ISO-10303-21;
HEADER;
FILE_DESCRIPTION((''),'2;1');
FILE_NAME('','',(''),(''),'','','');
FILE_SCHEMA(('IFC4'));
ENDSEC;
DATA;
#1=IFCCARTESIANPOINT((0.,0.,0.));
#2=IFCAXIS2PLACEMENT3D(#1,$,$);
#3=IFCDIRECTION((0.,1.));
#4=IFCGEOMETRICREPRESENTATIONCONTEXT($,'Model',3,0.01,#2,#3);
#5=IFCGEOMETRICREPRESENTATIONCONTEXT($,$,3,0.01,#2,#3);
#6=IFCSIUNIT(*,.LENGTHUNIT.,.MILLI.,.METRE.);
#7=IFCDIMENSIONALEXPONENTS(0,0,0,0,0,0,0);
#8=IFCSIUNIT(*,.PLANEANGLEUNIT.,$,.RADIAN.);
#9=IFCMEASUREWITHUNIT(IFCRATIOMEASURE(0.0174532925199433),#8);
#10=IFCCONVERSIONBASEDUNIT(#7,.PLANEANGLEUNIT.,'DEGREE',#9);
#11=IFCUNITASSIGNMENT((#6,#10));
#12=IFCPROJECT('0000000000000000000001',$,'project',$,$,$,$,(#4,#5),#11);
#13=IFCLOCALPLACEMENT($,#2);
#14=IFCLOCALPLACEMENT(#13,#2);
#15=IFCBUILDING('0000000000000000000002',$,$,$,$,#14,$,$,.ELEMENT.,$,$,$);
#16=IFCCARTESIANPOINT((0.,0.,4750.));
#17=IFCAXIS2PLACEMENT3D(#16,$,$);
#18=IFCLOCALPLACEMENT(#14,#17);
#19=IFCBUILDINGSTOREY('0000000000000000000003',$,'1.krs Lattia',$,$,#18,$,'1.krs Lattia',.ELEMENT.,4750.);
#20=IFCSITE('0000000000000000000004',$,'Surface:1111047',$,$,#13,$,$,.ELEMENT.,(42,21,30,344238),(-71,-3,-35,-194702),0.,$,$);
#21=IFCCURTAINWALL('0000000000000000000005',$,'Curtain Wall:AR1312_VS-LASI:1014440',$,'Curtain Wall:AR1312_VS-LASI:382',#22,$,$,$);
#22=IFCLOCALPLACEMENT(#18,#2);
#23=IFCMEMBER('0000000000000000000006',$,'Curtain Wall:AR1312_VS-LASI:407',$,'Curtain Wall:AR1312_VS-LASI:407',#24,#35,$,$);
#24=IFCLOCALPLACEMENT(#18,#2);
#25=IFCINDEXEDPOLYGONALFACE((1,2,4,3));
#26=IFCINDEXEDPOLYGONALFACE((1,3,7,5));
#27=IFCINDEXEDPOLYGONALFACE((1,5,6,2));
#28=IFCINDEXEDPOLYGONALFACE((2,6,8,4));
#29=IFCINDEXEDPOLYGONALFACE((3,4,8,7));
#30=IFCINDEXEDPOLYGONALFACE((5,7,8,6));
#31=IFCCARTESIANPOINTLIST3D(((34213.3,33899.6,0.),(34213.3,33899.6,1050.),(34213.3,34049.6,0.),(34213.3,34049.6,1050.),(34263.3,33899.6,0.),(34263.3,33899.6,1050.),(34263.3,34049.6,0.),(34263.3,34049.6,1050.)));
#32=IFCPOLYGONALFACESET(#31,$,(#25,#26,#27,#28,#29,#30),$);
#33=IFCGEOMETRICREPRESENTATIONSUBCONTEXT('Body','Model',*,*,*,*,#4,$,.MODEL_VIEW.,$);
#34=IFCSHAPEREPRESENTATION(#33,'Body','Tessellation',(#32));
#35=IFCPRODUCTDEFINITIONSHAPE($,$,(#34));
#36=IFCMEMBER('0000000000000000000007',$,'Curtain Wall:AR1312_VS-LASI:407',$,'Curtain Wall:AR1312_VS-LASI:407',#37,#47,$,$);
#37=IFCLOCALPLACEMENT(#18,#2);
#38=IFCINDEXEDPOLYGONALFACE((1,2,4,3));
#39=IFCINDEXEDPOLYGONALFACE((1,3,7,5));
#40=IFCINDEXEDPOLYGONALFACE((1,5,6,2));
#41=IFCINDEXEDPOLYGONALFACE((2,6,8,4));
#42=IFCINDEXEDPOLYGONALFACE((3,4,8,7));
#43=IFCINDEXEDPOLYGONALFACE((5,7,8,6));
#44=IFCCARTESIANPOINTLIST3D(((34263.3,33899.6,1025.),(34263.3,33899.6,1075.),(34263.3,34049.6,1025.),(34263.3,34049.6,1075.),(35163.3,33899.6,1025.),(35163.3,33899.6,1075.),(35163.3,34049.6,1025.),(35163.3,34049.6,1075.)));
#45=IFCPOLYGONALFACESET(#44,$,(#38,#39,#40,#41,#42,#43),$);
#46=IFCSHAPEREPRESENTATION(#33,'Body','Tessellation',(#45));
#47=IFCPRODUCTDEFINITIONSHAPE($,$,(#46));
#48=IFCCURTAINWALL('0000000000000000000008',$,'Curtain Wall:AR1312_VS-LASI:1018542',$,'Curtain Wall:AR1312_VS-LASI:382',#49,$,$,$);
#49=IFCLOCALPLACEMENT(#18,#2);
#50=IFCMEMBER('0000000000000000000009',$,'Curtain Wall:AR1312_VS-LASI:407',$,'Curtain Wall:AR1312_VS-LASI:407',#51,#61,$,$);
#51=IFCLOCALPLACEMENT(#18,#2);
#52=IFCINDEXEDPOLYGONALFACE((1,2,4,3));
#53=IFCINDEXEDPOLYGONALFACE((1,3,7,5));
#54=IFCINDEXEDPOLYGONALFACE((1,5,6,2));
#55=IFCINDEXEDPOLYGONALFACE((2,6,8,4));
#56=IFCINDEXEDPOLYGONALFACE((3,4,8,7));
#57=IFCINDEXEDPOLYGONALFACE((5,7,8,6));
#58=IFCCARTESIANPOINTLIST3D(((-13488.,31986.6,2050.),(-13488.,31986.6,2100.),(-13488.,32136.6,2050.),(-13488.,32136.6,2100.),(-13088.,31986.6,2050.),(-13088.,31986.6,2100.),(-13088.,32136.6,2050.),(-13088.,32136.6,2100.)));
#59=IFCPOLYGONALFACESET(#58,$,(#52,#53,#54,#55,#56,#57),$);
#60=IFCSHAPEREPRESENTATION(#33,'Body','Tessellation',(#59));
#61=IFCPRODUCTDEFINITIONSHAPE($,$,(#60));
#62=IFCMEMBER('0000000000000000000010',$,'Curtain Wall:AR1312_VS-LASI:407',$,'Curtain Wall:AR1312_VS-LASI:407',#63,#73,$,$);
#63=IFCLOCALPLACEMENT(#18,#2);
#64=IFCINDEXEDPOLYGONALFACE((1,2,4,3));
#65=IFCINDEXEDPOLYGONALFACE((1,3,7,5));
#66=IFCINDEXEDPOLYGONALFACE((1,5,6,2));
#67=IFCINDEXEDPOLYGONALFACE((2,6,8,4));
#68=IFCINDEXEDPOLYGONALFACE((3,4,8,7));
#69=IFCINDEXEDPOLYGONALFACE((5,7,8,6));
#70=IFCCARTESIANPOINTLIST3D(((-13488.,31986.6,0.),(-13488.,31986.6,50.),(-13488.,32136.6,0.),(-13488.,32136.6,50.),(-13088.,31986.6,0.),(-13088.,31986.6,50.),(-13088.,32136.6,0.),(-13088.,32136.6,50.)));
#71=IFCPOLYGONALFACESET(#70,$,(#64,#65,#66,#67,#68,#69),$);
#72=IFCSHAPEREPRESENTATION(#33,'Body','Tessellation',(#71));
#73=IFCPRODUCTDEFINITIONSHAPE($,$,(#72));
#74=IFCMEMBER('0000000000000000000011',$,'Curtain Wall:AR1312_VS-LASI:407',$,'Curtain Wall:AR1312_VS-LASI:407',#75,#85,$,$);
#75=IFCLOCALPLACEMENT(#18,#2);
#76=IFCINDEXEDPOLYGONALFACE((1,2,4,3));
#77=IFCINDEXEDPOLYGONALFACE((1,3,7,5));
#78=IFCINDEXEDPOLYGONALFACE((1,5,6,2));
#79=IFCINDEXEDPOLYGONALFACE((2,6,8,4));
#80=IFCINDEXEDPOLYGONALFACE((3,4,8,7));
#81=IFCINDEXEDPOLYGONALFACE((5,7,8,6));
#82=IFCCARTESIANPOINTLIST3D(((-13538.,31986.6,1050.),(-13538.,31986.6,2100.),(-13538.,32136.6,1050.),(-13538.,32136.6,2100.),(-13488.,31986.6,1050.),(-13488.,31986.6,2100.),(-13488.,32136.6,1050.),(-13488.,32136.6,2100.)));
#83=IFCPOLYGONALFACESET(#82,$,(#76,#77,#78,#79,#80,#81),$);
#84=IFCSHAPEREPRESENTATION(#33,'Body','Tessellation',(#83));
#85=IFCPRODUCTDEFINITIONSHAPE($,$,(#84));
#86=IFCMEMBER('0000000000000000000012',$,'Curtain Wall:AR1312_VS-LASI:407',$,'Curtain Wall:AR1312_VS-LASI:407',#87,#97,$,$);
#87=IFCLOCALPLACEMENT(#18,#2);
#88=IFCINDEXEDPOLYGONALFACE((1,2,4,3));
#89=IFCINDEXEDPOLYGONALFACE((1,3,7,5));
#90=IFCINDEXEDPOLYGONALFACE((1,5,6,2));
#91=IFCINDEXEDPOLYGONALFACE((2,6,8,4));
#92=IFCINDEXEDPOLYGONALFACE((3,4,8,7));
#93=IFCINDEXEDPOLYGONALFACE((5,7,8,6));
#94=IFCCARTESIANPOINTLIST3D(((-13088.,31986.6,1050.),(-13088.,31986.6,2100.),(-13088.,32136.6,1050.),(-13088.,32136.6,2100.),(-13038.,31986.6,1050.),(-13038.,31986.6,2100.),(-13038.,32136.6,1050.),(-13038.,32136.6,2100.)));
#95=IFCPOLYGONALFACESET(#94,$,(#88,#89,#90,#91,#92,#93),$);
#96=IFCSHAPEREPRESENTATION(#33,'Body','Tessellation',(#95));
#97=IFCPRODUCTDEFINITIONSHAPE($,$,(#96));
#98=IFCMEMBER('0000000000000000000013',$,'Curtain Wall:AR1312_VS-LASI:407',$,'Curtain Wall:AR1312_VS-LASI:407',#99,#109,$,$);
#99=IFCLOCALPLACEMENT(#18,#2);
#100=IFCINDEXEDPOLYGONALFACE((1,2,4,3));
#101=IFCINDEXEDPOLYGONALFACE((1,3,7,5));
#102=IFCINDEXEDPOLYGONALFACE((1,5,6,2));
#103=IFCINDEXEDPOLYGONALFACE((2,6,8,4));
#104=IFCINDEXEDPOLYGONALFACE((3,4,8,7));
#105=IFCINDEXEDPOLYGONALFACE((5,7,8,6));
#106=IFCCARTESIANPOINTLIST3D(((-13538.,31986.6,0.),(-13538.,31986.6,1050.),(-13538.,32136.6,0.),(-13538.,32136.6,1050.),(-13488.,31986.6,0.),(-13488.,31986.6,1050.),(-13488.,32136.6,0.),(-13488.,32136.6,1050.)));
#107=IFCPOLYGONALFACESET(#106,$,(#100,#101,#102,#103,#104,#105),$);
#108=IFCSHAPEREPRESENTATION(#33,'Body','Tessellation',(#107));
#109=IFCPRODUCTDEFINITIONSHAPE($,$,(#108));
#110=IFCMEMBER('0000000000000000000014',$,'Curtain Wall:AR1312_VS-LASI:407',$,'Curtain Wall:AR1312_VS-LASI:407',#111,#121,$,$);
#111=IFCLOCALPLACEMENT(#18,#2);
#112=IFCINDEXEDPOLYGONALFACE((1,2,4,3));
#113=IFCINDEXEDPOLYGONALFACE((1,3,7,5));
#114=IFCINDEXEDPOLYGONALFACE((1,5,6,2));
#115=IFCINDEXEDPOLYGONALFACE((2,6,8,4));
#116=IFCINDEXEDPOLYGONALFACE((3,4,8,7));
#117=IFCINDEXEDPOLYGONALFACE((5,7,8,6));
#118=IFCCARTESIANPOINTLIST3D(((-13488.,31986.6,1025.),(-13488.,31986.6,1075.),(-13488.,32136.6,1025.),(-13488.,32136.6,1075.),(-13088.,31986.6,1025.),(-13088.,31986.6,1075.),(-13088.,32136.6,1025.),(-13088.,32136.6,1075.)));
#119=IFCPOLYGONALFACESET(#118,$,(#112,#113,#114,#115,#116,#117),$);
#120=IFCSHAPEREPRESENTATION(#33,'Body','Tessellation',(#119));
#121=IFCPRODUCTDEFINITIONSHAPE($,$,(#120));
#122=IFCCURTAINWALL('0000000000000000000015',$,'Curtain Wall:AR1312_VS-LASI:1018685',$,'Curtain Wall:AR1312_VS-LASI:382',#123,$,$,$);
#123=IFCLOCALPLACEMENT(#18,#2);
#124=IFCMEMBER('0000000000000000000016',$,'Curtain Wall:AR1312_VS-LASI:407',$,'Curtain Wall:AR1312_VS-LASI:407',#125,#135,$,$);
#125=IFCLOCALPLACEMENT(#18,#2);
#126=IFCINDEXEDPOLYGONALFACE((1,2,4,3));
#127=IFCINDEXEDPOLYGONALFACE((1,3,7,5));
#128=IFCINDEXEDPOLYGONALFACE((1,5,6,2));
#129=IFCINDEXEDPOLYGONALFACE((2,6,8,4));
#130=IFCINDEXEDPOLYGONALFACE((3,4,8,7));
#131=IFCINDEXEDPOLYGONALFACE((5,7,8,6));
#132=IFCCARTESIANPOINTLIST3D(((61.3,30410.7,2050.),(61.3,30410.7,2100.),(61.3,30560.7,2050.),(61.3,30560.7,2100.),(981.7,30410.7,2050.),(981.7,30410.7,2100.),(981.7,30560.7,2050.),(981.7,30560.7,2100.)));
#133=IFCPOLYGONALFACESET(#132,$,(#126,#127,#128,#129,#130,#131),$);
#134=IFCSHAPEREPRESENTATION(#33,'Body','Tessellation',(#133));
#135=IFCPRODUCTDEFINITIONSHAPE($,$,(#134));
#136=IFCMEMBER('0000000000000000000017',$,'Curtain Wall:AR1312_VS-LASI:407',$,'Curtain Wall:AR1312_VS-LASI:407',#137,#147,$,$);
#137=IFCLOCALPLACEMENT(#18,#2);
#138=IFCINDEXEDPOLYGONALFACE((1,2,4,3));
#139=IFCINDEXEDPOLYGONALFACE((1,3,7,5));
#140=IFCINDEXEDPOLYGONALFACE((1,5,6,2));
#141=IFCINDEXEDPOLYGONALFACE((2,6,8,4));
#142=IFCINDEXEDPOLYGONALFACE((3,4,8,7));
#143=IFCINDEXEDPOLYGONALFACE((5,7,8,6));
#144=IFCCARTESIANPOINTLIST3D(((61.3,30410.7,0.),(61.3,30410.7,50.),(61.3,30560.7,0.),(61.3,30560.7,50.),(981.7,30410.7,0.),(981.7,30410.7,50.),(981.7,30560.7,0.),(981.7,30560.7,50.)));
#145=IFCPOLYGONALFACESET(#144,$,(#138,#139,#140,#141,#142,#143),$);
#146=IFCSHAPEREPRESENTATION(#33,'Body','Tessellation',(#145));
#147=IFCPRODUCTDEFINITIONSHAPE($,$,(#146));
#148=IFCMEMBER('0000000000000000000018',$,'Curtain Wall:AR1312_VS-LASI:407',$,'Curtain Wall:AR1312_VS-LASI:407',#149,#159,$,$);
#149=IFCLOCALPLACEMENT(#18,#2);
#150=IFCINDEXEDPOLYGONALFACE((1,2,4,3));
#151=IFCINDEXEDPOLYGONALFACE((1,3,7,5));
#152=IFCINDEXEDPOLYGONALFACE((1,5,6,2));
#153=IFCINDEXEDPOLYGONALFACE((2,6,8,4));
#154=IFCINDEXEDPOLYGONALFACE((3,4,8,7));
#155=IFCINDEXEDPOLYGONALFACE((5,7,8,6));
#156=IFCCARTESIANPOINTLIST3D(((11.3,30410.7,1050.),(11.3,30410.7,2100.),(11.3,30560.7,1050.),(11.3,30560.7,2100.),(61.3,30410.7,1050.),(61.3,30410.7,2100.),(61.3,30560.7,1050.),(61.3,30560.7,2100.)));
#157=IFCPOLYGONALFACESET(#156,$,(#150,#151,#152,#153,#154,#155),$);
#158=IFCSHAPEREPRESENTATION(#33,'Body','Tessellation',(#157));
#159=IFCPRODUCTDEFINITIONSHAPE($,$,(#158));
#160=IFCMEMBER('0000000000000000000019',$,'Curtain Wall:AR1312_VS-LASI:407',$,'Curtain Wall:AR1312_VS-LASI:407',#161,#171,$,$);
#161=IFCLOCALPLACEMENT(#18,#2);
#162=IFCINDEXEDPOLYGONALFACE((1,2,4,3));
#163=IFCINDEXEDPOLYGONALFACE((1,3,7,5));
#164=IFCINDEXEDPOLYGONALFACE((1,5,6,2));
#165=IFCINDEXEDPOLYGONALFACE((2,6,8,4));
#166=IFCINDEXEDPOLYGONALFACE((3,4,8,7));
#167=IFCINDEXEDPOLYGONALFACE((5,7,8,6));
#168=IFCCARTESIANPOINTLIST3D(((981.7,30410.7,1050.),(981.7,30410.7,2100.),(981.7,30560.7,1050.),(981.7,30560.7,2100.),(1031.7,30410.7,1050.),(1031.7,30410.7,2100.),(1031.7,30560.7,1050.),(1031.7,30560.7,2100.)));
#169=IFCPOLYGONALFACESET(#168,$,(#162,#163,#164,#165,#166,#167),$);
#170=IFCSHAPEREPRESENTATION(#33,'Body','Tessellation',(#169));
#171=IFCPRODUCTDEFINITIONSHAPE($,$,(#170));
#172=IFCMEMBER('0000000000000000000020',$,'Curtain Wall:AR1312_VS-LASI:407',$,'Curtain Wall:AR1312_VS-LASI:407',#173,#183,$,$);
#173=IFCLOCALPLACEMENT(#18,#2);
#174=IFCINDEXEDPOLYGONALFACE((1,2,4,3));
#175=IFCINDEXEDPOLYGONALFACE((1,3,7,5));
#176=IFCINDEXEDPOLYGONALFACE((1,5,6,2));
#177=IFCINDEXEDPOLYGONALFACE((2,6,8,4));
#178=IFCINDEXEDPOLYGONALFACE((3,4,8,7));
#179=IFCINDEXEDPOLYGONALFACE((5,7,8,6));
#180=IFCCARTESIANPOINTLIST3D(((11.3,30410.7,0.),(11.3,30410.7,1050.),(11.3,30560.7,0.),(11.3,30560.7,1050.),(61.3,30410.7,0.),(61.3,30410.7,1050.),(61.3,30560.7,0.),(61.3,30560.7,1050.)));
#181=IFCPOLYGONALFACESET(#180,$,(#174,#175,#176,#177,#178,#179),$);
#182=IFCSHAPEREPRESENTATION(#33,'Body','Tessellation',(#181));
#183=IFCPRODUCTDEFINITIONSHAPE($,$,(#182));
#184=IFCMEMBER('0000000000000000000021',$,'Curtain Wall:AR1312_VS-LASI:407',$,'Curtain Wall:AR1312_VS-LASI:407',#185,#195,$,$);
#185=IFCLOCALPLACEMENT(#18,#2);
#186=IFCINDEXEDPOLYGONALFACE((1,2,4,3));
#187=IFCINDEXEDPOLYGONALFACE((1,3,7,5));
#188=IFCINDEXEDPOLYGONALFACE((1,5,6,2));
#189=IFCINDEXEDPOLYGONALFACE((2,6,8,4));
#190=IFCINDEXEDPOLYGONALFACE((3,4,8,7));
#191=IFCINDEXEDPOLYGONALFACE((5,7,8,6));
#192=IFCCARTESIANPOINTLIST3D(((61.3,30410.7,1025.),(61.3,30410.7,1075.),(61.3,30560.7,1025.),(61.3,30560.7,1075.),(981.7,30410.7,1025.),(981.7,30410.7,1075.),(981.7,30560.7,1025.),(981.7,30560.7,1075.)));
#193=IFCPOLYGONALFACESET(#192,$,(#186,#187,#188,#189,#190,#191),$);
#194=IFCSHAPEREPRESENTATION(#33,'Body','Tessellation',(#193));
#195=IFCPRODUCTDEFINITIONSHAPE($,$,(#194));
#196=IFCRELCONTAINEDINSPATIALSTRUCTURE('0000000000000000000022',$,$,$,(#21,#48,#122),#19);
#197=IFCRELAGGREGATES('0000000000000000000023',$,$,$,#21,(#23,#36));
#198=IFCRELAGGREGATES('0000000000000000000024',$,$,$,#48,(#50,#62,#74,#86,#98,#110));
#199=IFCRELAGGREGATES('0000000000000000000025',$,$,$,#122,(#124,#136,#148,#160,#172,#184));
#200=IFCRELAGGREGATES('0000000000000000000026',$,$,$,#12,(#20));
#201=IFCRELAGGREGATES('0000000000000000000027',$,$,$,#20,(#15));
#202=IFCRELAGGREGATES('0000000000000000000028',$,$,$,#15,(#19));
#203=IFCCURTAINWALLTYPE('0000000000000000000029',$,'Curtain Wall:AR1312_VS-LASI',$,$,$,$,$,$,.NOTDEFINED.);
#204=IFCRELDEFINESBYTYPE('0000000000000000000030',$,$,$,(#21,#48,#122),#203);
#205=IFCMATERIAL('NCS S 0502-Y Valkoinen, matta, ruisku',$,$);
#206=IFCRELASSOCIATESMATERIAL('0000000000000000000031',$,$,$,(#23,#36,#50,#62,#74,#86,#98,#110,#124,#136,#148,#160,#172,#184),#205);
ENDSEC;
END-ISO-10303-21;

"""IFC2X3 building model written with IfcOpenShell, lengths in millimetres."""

from ifc_helpers import new_model, entity, si_unit, converted_unit, direction, frame, frame_2d, origin, origin_2d_with_axis, place, context, subcontext, project, spatial, rectangle, extrude, material, type_object, element, aggregate, save


model = new_model("IFC2X3")

# Units and contexts
model_context = context("Model", 3, precision=0.01, world=origin(), true_north=direction((0.0, 1.0)))
context_of_model = context(None, 3, precision=0.01, world=origin(), true_north=direction((0.0, 1.0)))
body_context = subcontext(model_context, "Body", "Model", "MODEL_VIEW")
ifc_project = project(units=[si_unit("LENGTHUNIT", "METRE", prefix="MILLI"), converted_unit("PLANEANGLEUNIT", "DEGREE", entity("IfcRatioMeasure", 0.0174532925199433), si_unit("PLANEANGLEUNIT", "RADIAN"), dimensions=[0, 0, 0, 0, 0, 0, 0])], contexts=[model_context, context_of_model])

# Site, building, storey
site_placement = place(None, origin())
site = spatial("IfcSite", under=ifc_project, at=site_placement, Name="Surface:1111047", CompositionType="ELEMENT", RefLatitude=(42, 21, 30, 344238), RefLongitude=(-71, -3, -35, -194702), RefElevation=0.0)
building_placement = place(site_placement, origin())
building = spatial("IfcBuilding", under=site, at=building_placement, CompositionType="ELEMENT")
storey_placement = place(building_placement, frame((0.0, 0.0, 4750.0)))
storey = spatial("IfcBuildingStorey", under=building, at=storey_placement, Name="1.krs Lattia", LongName="1.krs Lattia", CompositionType="ELEMENT", Elevation=4750.0)

# Curtain walls, members
curtain_wall_type = type_object("IfcCurtainWallType", Name="Curtain Wall:AR1312_VS-LASI", PredefinedType="NOTDEFINED")
ifc_material = material(Name="NCS S 0502-Y Valkoinen, matta, ruisku")
curtain_wall_1_placement = place(storey_placement, frame((0.0, 0.0, -4750.0)))
curtain_wall_1 = element("IfcCurtainWall", 1, at=curtain_wall_1_placement, inside=storey, type_object=curtain_wall_type, Name="Curtain Wall:AR1312_VS-LASI:1014440", ObjectType="Curtain Wall:AR1312_VS-LASI:382")
member_1_placement = place(curtain_wall_1_placement, frame((0.0, 0.0, 4750.0)))
member_1 = element("IfcMember", 2, at=member_1_placement, material=ifc_material, Name="Curtain Wall:AR1312_VS-LASI:407", ObjectType="Curtain Wall:AR1312_VS-LASI:407", context=body_context, shape_type="SweptSolid", body=[
    extrude(rectangle(XDim=50.0, YDim=150.0, at=frame_2d((0.0, 0.0), x_axis=(1.0, 0.0))), frame((34238.3, 33974.6, 1050.0), z_axis=(0.0, 0.0, -1.0), x_axis=(-1.0, 0.0, 0.0)), (0.0, 0.0, 1.0), 1050.0),
])
member_2_placement = place(curtain_wall_1_placement, frame((0.0, 0.0, 4750.0)))
member_2 = element("IfcMember", 3, at=member_2_placement, material=ifc_material, Name="Curtain Wall:AR1312_VS-LASI:407", ObjectType="Curtain Wall:AR1312_VS-LASI:407", context=body_context, shape_type="SweptSolid", body=[
    extrude(rectangle(XDim=50.0, YDim=150.0, at=frame_2d((0.0, 0.0), x_axis=(1.0, 0.0))), frame((35163.3, 33974.6, 1050.0), z_axis=(-1.0, 0.0, 0.0), x_axis=(0.0, 0.0, -1.0)), (0.0, 0.0, 1.0), 900.0),
])
aggregate(curtain_wall_1, [member_1, member_2])
curtain_wall_2_placement = place(storey_placement, frame((0.0, 0.0, -4750.0)))
curtain_wall_2 = element("IfcCurtainWall", 4, at=curtain_wall_2_placement, inside=storey, type_object=curtain_wall_type, Name="Curtain Wall:AR1312_VS-LASI:1018542", ObjectType="Curtain Wall:AR1312_VS-LASI:382")
member_3_placement = place(curtain_wall_2_placement, frame((0.0, 0.0, 4750.0)))
member_3 = element("IfcMember", 5, at=member_3_placement, material=ifc_material, Name="Curtain Wall:AR1312_VS-LASI:407", ObjectType="Curtain Wall:AR1312_VS-LASI:407", context=body_context, shape_type="SweptSolid", body=[
    extrude(rectangle(XDim=50.0, YDim=150.0, at=frame_2d((0.0, 0.0), x_axis=(1.0, 0.0))), frame((-13088.0, 32061.6, 2075.0), z_axis=(-1.0, 0.0, 0.0), x_axis=(0.0, 0.0, -1.0)), (0.0, 0.0, 1.0), 400.0),
])
member_4_placement = place(curtain_wall_2_placement, frame((0.0, 0.0, 4750.0)))
member_4 = element("IfcMember", 6, at=member_4_placement, material=ifc_material, Name="Curtain Wall:AR1312_VS-LASI:407", ObjectType="Curtain Wall:AR1312_VS-LASI:407", context=body_context, shape_type="SweptSolid", body=[
    extrude(rectangle(XDim=50.0, YDim=150.0, at=frame_2d((0.0, 0.0), x_axis=(1.0, 0.0))), frame((-13488.0, 32061.6, 25.0), z_axis=(1.0, 0.0, 0.0), x_axis=(0.0, 0.0, -1.0)), (0.0, 0.0, 1.0), 400.0),
])
member_5_placement = place(curtain_wall_2_placement, frame((0.0, 0.0, 4750.0)))
member_5 = element("IfcMember", 7, at=member_5_placement, material=ifc_material, Name="Curtain Wall:AR1312_VS-LASI:407", ObjectType="Curtain Wall:AR1312_VS-LASI:407", context=body_context, shape_type="SweptSolid", body=[
    extrude(rectangle(XDim=50.0, YDim=150.0, at=frame_2d((0.0, 0.0), x_axis=(1.0, 0.0))), frame((-13513.0, 32061.6, 2100.0), z_axis=(0.0, 0.0, -1.0), x_axis=(-1.0, 0.0, 0.0)), (0.0, 0.0, 1.0), 1050.0),
])
member_6_placement = place(curtain_wall_2_placement, frame((0.0, 0.0, 4750.0)))
member_6 = element("IfcMember", 8, at=member_6_placement, material=ifc_material, Name="Curtain Wall:AR1312_VS-LASI:407", ObjectType="Curtain Wall:AR1312_VS-LASI:407", context=body_context, shape_type="SweptSolid", body=[
    extrude(rectangle(XDim=50.0, YDim=150.0, at=frame_2d((0.0, 0.0), x_axis=(1.0, 0.0))), frame((-13063.0, 32061.6, 1050.0), z_axis=(0.0, 0.0, 1.0), x_axis=(-1.0, 0.0, 0.0)), (0.0, 0.0, 1.0), 1050.0),
])
member_7_placement = place(curtain_wall_2_placement, frame((0.0, 0.0, 4750.0)))
member_7 = element("IfcMember", 9, at=member_7_placement, material=ifc_material, Name="Curtain Wall:AR1312_VS-LASI:407", ObjectType="Curtain Wall:AR1312_VS-LASI:407", context=body_context, shape_type="SweptSolid", body=[
    extrude(rectangle(XDim=50.0, YDim=150.0, at=frame_2d((0.0, 0.0), x_axis=(1.0, 0.0))), frame((-13513.0, 32061.6, 1050.0), z_axis=(0.0, 0.0, -1.0), x_axis=(-1.0, 0.0, 0.0)), (0.0, 0.0, 1.0), 1050.0),
])
member_8_placement = place(curtain_wall_2_placement, frame((0.0, 0.0, 4750.0)))
member_8 = element("IfcMember", 10, at=member_8_placement, material=ifc_material, Name="Curtain Wall:AR1312_VS-LASI:407", ObjectType="Curtain Wall:AR1312_VS-LASI:407", context=body_context, shape_type="SweptSolid", body=[
    extrude(rectangle(XDim=50.0, YDim=150.0, at=origin_2d_with_axis()), frame((-13088.0, 32061.6, 1050.0), z_axis=(-1.0, 0.0, 0.0), x_axis=(0.0, 0.0, -1.0)), (0.0, 0.0, 1.0), 400.0),
])
aggregate(curtain_wall_2, [member_3, member_4, member_5, member_6, member_7, member_8])
curtain_wall_3_placement = place(storey_placement, frame((0.0, 0.0, -4750.0)))
curtain_wall_3 = element("IfcCurtainWall", 11, at=curtain_wall_3_placement, inside=storey, type_object=curtain_wall_type, Name="Curtain Wall:AR1312_VS-LASI:1018685", ObjectType="Curtain Wall:AR1312_VS-LASI:382")
member_9_placement = place(curtain_wall_3_placement, frame((0.0, 0.0, 4750.0)))
member_9 = element("IfcMember", 12, at=member_9_placement, material=ifc_material, Name="Curtain Wall:AR1312_VS-LASI:407", ObjectType="Curtain Wall:AR1312_VS-LASI:407", context=body_context, shape_type="SweptSolid", body=[
    extrude(rectangle(XDim=50.0, YDim=150.0, at=frame_2d((0.0, 0.0), x_axis=(1.0, 0.0))), frame((981.7, 30485.7, 2075.0), z_axis=(-1.0, 0.0, 0.0), x_axis=(0.0, 0.0, -1.0)), (0.0, 0.0, 1.0), 920.4),
])
member_10_placement = place(curtain_wall_3_placement, frame((0.0, 0.0, 4750.0)))
member_10 = element("IfcMember", 13, at=member_10_placement, material=ifc_material, Name="Curtain Wall:AR1312_VS-LASI:407", ObjectType="Curtain Wall:AR1312_VS-LASI:407", context=body_context, shape_type="SweptSolid", body=[
    extrude(rectangle(XDim=50.0, YDim=150.0, at=frame_2d((0.0, 0.0), x_axis=(1.0, 0.0))), frame((61.3, 30485.7, 25.0), z_axis=(1.0, 0.0, 0.0), x_axis=(0.0, 0.0, -1.0)), (0.0, 0.0, 1.0), 920.4),
])
member_11_placement = place(curtain_wall_3_placement, frame((0.0, 0.0, 4750.0)))
member_11 = element("IfcMember", 14, at=member_11_placement, material=ifc_material, Name="Curtain Wall:AR1312_VS-LASI:407", ObjectType="Curtain Wall:AR1312_VS-LASI:407", context=body_context, shape_type="SweptSolid", body=[
    extrude(rectangle(XDim=50.0, YDim=150.0, at=frame_2d((0.0, 0.0), x_axis=(1.0, 0.0))), frame((36.3, 30485.7, 2100.0), z_axis=(0.0, 0.0, -1.0), x_axis=(-1.0, 0.0, 0.0)), (0.0, 0.0, 1.0), 1050.0),
])
member_12_placement = place(curtain_wall_3_placement, frame((0.0, 0.0, 4750.0)))
member_12 = element("IfcMember", 15, at=member_12_placement, material=ifc_material, Name="Curtain Wall:AR1312_VS-LASI:407", ObjectType="Curtain Wall:AR1312_VS-LASI:407", context=body_context, shape_type="SweptSolid", body=[
    extrude(rectangle(XDim=50.0, YDim=150.0, at=origin_2d_with_axis()), frame((1006.7, 30485.7, 1050.0), z_axis=(0.0, 0.0, 1.0), x_axis=(-1.0, 0.0, 0.0)), (0.0, 0.0, 1.0), 1050.0),
])
member_13_placement = place(curtain_wall_3_placement, frame((0.0, 0.0, 4750.0)))
member_13 = element("IfcMember", 16, at=member_13_placement, material=ifc_material, Name="Curtain Wall:AR1312_VS-LASI:407", ObjectType="Curtain Wall:AR1312_VS-LASI:407", context=body_context, shape_type="SweptSolid", body=[
    extrude(rectangle(XDim=50.0, YDim=150.0, at=frame_2d((0.0, 0.0), x_axis=(1.0, 0.0))), frame((36.3, 30485.7, 1050.0), z_axis=(0.0, 0.0, -1.0), x_axis=(-1.0, 0.0, 0.0)), (0.0, 0.0, 1.0), 1050.0),
])
member_14_placement = place(curtain_wall_3_placement, frame((0.0, 0.0, 4750.0)))
member_14 = element("IfcMember", 17, at=member_14_placement, material=ifc_material, Name="Curtain Wall:AR1312_VS-LASI:407", ObjectType="Curtain Wall:AR1312_VS-LASI:407", context=body_context, shape_type="SweptSolid", body=[
    extrude(rectangle(XDim=50.0, YDim=150.0, at=frame_2d((0.0, 0.0), x_axis=(1.0, 0.0))), frame((981.7, 30485.7, 1050.0), z_axis=(-1.0, 0.0, 0.0), x_axis=(0.0, 0.0, -1.0)), (0.0, 0.0, 1.0), 920.4),
])
aggregate(curtain_wall_3, [member_9, member_10, member_11, member_12, member_13, member_14])

save(model, "model.ifc")
